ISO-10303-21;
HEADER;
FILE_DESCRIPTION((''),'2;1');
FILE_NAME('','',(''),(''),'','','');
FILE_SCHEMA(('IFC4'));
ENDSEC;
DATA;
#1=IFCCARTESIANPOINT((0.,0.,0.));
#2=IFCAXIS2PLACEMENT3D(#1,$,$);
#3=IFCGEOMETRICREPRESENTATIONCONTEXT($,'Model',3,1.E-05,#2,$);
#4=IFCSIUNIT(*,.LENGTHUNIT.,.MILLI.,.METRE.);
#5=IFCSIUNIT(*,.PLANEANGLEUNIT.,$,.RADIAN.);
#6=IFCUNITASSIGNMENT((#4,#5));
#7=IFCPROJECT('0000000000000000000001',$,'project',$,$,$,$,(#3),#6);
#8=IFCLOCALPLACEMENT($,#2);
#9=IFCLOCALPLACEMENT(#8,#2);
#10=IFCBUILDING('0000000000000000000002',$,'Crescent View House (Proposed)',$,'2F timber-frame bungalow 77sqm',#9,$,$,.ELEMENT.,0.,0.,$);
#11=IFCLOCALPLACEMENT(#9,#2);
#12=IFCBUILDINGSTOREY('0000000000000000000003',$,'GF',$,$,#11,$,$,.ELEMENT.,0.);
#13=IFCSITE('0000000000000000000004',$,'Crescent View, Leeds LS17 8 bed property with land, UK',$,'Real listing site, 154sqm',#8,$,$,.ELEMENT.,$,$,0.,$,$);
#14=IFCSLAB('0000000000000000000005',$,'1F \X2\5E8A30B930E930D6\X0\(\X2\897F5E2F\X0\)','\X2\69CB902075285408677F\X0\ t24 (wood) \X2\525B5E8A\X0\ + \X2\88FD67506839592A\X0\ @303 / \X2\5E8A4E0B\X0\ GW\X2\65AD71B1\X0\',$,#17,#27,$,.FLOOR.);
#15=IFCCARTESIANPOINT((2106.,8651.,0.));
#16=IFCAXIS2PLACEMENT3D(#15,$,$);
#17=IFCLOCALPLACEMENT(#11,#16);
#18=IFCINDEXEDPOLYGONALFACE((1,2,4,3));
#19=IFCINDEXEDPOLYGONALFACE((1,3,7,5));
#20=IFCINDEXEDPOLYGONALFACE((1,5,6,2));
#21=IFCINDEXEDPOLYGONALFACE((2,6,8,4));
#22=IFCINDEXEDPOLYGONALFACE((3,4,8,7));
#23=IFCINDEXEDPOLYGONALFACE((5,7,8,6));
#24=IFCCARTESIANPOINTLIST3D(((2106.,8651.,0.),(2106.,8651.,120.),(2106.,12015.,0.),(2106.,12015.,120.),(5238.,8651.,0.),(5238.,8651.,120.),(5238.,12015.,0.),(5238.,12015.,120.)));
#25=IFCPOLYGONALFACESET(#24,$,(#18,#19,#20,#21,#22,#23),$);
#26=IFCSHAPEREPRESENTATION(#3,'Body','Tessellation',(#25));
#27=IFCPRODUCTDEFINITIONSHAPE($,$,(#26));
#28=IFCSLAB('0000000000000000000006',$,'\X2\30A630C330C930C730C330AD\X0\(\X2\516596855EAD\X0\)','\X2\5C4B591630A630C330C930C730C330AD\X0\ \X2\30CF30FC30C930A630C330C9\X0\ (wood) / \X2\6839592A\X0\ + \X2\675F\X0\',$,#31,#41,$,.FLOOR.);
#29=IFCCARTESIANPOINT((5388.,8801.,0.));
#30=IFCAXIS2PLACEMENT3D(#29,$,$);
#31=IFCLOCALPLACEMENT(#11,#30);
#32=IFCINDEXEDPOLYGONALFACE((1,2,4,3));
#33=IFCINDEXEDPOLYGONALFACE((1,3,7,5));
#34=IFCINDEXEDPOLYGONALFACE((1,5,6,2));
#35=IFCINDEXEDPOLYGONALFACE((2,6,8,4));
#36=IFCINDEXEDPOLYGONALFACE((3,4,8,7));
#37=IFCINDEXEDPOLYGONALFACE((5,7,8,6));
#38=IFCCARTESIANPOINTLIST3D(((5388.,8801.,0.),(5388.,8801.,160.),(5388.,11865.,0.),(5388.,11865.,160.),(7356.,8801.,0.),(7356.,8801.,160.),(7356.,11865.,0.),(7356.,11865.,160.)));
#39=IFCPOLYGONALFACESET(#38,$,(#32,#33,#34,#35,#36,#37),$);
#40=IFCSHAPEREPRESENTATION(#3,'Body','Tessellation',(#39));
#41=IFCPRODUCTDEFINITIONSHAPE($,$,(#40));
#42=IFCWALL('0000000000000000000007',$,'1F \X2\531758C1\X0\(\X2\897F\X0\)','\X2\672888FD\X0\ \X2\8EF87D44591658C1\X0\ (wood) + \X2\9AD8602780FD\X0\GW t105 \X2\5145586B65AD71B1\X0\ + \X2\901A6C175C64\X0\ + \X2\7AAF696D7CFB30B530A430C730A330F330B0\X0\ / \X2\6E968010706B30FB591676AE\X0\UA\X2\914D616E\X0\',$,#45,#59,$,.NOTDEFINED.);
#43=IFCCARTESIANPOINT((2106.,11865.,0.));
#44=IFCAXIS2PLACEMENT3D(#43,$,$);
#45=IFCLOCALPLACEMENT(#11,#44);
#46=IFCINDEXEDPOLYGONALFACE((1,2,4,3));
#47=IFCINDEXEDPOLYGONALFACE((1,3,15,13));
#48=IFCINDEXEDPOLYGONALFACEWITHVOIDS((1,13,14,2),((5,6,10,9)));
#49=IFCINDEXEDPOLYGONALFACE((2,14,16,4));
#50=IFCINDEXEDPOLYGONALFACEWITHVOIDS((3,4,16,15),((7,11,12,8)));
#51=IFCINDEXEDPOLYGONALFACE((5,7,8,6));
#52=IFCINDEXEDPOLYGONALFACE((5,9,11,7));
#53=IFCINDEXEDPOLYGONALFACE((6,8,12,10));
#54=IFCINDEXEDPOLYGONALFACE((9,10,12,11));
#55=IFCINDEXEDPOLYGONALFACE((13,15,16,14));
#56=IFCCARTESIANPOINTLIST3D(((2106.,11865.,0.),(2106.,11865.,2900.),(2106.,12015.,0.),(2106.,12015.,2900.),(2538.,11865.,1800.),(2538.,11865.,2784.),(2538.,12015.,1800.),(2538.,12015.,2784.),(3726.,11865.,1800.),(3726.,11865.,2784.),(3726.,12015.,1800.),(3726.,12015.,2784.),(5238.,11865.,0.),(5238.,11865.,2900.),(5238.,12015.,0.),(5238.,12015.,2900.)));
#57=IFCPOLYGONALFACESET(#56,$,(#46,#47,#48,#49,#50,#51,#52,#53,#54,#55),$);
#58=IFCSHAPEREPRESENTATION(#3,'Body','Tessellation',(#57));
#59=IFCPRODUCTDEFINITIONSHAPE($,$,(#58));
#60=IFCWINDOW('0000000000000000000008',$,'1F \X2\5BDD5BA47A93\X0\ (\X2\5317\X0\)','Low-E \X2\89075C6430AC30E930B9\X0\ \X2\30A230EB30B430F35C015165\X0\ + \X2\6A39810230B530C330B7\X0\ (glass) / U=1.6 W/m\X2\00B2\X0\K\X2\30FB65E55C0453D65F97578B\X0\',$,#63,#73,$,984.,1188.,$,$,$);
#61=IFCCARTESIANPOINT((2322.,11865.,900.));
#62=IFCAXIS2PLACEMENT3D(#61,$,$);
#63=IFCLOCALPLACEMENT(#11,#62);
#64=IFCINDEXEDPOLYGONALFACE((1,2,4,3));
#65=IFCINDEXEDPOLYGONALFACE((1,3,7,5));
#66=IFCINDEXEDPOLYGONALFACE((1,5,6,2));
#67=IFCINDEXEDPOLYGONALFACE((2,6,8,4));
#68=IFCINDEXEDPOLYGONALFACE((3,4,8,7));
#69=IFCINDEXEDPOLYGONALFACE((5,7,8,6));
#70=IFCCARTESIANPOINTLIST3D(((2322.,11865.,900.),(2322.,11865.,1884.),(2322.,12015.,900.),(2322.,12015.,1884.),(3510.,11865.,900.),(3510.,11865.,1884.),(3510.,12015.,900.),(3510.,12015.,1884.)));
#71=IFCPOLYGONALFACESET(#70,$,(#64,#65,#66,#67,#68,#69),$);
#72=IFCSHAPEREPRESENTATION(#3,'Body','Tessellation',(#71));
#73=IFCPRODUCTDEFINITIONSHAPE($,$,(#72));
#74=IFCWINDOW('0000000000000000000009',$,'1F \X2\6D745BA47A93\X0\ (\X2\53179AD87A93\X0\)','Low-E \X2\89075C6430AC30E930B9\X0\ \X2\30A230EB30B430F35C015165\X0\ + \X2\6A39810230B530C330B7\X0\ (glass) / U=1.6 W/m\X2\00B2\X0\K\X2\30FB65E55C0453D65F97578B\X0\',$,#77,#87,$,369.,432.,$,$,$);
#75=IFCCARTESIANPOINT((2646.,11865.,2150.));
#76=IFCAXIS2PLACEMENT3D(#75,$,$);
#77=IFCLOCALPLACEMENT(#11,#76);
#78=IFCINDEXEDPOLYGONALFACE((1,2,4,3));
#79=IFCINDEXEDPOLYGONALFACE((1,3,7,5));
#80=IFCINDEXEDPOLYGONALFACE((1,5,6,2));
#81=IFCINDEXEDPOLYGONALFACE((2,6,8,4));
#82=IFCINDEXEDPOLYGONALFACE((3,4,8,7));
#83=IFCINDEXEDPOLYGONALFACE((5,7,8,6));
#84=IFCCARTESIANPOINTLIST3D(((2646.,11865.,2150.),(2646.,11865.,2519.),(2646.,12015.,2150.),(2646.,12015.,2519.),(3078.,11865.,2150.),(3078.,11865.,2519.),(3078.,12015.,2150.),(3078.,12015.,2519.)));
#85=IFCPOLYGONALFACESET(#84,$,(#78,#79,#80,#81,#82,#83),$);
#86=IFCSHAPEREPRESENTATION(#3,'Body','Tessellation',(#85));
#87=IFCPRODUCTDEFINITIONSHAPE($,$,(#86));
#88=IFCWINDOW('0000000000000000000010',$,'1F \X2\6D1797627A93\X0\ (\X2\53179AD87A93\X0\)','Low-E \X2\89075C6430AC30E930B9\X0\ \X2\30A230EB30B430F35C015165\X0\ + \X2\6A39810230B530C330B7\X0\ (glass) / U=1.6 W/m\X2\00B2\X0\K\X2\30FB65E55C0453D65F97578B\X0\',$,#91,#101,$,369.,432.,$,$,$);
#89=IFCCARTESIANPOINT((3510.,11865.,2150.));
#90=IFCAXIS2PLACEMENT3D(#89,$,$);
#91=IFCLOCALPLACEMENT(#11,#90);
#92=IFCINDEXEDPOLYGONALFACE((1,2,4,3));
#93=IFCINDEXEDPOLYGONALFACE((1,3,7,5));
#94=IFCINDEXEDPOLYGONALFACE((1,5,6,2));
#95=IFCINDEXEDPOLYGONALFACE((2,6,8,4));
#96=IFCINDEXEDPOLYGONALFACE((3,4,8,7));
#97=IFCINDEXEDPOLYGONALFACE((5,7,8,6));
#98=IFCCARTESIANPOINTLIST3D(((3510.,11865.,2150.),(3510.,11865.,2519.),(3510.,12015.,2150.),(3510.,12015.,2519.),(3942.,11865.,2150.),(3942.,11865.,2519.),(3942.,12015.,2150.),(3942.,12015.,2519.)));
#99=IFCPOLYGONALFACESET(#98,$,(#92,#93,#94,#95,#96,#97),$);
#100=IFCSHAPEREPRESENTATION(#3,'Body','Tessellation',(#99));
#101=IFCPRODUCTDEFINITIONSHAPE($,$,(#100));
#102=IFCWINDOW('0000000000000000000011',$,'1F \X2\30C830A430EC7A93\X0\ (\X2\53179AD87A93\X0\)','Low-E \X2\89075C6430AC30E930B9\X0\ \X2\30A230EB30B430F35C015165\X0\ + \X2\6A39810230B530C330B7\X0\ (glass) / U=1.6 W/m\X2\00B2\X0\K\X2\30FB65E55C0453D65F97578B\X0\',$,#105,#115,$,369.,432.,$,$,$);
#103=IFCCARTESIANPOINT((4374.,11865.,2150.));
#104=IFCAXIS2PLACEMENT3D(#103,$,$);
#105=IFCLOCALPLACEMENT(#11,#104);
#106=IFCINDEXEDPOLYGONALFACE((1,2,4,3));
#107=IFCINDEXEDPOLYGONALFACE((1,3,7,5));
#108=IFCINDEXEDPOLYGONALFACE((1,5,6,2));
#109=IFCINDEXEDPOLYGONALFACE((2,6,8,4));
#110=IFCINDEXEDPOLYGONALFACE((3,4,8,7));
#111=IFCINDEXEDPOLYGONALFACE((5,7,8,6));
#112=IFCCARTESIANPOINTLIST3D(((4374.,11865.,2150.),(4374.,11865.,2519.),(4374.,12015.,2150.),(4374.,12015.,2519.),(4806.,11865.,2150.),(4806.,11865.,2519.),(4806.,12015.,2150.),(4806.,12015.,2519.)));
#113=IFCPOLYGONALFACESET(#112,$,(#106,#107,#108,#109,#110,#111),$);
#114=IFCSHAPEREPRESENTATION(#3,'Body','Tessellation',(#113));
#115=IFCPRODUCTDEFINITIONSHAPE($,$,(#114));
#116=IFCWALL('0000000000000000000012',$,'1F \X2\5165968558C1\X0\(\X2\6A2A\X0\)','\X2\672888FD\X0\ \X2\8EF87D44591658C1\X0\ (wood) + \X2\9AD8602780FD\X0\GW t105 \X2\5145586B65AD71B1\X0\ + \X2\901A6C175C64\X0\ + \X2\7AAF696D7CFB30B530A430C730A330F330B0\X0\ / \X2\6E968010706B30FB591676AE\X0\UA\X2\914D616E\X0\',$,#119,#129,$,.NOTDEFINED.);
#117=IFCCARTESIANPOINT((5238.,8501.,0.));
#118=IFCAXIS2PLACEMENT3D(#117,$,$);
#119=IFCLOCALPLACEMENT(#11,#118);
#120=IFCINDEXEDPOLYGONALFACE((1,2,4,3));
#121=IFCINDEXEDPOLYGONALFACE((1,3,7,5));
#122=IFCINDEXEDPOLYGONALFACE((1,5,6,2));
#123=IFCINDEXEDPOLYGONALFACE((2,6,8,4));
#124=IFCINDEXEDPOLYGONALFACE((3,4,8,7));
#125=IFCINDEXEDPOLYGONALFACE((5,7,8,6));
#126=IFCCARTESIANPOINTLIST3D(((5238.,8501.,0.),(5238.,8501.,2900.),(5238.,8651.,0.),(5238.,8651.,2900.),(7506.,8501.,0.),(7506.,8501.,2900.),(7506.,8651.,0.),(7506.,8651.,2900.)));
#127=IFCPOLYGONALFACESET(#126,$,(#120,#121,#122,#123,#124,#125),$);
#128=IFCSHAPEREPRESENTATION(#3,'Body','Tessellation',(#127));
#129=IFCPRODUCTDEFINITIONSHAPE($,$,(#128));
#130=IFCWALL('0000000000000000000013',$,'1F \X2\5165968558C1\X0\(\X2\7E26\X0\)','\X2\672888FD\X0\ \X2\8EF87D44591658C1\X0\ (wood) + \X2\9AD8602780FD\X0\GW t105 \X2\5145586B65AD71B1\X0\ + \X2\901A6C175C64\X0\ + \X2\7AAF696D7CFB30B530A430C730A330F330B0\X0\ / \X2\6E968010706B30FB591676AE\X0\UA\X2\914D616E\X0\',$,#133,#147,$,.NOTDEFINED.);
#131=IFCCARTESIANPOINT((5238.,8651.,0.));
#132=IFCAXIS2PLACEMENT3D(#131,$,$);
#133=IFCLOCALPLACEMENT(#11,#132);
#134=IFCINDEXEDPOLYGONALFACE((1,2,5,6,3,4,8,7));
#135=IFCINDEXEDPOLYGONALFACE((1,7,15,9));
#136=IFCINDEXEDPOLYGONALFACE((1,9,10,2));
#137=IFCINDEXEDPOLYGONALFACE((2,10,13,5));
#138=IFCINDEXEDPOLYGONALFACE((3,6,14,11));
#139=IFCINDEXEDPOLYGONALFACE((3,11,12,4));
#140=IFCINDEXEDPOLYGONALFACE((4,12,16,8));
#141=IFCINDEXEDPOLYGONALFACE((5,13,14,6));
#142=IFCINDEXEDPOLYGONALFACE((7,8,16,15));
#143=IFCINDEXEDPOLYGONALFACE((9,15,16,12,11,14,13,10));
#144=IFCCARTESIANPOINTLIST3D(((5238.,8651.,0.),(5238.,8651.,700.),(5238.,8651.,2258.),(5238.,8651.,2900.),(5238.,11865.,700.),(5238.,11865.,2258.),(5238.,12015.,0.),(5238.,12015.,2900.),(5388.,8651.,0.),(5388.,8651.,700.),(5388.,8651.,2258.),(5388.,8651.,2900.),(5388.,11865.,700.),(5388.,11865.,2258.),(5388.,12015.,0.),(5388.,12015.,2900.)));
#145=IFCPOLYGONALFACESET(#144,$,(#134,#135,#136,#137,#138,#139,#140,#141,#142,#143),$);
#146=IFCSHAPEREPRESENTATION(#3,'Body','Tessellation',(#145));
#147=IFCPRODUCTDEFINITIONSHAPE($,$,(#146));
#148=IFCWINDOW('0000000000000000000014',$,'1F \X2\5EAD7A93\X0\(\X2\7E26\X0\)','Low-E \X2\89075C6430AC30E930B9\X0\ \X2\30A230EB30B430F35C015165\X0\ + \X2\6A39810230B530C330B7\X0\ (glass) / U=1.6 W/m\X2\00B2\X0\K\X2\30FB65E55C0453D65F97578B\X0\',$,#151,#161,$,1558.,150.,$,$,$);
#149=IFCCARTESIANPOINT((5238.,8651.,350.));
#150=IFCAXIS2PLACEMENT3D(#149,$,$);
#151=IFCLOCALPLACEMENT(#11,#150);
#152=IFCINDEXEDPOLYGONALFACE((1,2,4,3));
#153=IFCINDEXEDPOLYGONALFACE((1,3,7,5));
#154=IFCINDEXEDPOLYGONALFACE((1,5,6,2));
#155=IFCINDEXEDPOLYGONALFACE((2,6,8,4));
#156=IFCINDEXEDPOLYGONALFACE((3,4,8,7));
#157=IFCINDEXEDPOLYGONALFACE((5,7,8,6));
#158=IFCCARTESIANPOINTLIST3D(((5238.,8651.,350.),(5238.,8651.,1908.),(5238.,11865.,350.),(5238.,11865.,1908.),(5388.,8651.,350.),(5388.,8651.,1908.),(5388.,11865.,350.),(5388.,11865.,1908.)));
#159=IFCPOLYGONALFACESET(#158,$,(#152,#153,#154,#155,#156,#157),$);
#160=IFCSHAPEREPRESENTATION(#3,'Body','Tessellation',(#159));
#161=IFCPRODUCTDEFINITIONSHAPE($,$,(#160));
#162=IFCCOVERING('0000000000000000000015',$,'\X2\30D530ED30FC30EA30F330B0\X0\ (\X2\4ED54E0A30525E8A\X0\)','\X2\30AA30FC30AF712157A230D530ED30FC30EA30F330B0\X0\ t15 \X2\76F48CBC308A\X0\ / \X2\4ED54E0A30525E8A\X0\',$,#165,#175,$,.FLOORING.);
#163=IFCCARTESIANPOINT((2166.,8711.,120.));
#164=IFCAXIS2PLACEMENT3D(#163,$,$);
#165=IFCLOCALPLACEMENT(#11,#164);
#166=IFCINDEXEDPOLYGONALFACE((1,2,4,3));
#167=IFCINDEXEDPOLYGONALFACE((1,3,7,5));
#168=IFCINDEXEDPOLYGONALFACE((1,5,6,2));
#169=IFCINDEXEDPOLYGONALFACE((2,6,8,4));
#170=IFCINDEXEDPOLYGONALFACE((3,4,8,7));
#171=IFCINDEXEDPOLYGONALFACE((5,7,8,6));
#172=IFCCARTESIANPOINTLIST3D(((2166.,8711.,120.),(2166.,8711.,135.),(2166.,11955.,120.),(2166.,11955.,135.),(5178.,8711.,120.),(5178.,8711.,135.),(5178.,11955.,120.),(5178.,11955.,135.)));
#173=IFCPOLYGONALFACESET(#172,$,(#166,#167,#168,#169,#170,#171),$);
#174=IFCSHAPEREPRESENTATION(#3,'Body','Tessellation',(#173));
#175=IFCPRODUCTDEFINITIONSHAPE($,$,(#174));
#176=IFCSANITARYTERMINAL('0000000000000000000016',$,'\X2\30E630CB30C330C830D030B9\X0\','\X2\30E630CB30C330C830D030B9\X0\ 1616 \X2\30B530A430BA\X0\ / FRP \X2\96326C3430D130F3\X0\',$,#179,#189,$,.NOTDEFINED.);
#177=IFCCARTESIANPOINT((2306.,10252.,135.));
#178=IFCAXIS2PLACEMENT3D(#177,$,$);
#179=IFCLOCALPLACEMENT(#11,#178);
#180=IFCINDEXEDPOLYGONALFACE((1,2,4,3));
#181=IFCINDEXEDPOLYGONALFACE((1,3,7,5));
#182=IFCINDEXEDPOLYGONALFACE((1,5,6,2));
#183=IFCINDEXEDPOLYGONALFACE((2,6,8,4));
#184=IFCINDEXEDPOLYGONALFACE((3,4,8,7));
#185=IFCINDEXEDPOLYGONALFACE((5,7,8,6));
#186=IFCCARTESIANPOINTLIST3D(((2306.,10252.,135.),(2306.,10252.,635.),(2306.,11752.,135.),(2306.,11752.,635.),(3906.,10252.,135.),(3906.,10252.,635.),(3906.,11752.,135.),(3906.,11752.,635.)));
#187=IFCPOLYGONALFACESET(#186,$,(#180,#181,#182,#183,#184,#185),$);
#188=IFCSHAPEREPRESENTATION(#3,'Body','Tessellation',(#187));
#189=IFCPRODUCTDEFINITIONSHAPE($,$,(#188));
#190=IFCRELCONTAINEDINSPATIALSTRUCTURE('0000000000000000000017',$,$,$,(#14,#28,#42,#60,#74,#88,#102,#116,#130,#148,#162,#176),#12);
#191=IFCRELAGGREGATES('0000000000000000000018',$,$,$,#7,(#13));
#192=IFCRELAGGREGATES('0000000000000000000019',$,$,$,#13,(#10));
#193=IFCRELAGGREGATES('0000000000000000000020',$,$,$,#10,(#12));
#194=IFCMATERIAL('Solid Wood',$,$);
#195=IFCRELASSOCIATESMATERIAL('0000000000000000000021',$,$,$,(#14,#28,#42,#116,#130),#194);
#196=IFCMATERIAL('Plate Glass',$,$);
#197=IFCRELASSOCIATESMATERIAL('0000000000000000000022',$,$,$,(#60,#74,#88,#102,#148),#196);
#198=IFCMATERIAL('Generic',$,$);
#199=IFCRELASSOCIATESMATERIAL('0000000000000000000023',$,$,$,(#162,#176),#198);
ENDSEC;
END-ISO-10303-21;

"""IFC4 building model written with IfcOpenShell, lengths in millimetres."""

from ifc_helpers import new_model, si_unit, frame, frame_2d, origin, place, context, project, spatial, rectangle, extrude, material, element, fill, save


model = new_model("IFC4")

# Units and contexts
model_context = context("Model", 3, precision=1e-05, world=origin())
ifc_project = project(units=[si_unit("LENGTHUNIT", "METRE", prefix="MILLI"), si_unit("PLANEANGLEUNIT", "RADIAN")], contexts=[model_context])

# Site, building, storey
site_placement = place(None, origin())
site = spatial("IfcSite", under=ifc_project, at=site_placement, Name="Crescent View, Leeds LS17 8 bed property with land, UK", ObjectType="Real listing site, 154sqm", CompositionType="ELEMENT", RefElevation=0.0)
building_placement = place(site_placement, origin())
building = spatial("IfcBuilding", under=site, at=building_placement, Name="Crescent View House (Proposed)", ObjectType="2F timber-frame bungalow 77sqm", CompositionType="ELEMENT", ElevationOfRefHeight=0.0, ElevationOfTerrain=0.0)
storey_placement = place(building_placement, origin())
storey = spatial("IfcBuildingStorey", under=building, at=storey_placement, Name="GF", CompositionType="ELEMENT", Elevation=0.0)

# Slabs
ifc_material_1 = material(Name="Solid Wood")
slab_1_placement = place(storey_placement, frame((2106.0, 8651.0, 0.0)))
element("IfcSlab", 1, at=slab_1_placement, inside=storey, material=ifc_material_1, Name="1F 床スラブ(西帯)", Description="構造用合板 t24 (wood) 剛床 + 製材根太 @303 / 床下 GW断熱", PredefinedType="FLOOR", context=model_context, shape_type="SweptSolid", body=[
    extrude(rectangle(XDim=3132.0, YDim=3364.0, at=frame_2d((1566.0, 1682.0))), frame((2106.0, 8651.0, 0.0)), (0.0, 0.0, 1.0), 120.0),
])
slab_2_placement = place(storey_placement, frame((5388.0, 8801.0, 0.0)))
element("IfcSlab", 2, at=slab_2_placement, inside=storey, material=ifc_material_1, Name="ウッドデッキ(入隅庭)", Description="屋外ウッドデッキ ハードウッド (wood) / 根太 + 束", PredefinedType="FLOOR", context=model_context, shape_type="SweptSolid", body=[
    extrude(rectangle(XDim=1968.0, YDim=3064.0, at=frame_2d((984.0, 1532.0))), frame((5388.0, 8801.0, 0.0)), (0.0, 0.0, 1.0), 160.0),
])

# Wall, openings, windows
wall_1_placement = place(storey_placement, frame((2106.0, 11865.0, 0.0)))
wall_1 = element("IfcWall", 3, at=wall_1_placement, inside=storey, material=ifc_material_1, Name="1F 北壁(西)", Description="木製 軸組外壁 (wood) + 高性能GW t105 充填断熱 + 通気層 + 窯業系サイディング / 準耐火・外皮UA配慮", PredefinedType="NOTDEFINED", context=model_context, shape_type="SweptSolid", body=[
    extrude(rectangle(XDim=3132.0, YDim=150.0, at=frame_2d((1566.0, 75.0))), frame((2106.0, 11865.0, 0.0)), (0.0, 0.0, 1.0), 2900.0),
])
opening_1_placement = place(storey_placement, frame((2322.0, 11865.0, 900.0)))
opening_1 = element("IfcOpeningElement", 4, at=opening_1_placement, cuts=wall_1, PredefinedType="NOTDEFINED", context=model_context, shape_type="SweptSolid", body=[
    extrude(rectangle(XDim=1188.0, YDim=150.0, at=frame_2d((594.0, 75.0))), frame((2322.0, 11865.0, 900.0)), (0.0, 0.0, 1.0), 984.0),
])
opening_2_placement = place(storey_placement, frame((2646.0, 11865.0, 2150.0)))
opening_2 = element("IfcOpeningElement", 5, at=opening_2_placement, cuts=wall_1, PredefinedType="NOTDEFINED", context=model_context, shape_type="SweptSolid", body=[
    extrude(rectangle(XDim=432.0, YDim=150.0, at=frame_2d((216.0, 75.0))), frame((2646.0, 11865.0, 2150.0)), (0.0, 0.0, 1.0), 369.0),
])
opening_3_placement = place(storey_placement, frame((3510.0, 11865.0, 2150.0)))
opening_3 = element("IfcOpeningElement", 6, at=opening_3_placement, cuts=wall_1, PredefinedType="NOTDEFINED", context=model_context, shape_type="SweptSolid", body=[
    extrude(rectangle(XDim=432.0, YDim=150.0, at=frame_2d((216.0, 75.0))), frame((3510.0, 11865.0, 2150.0)), (0.0, 0.0, 1.0), 369.0),
])
opening_4_placement = place(storey_placement, frame((4374.0, 11865.0, 2150.0)))
opening_4 = element("IfcOpeningElement", 7, at=opening_4_placement, cuts=wall_1, PredefinedType="NOTDEFINED", context=model_context, shape_type="SweptSolid", body=[
    extrude(rectangle(XDim=432.0, YDim=150.0, at=frame_2d((216.0, 75.0))), frame((4374.0, 11865.0, 2150.0)), (0.0, 0.0, 1.0), 369.0),
])
ifc_material_2 = material(Name="Plate Glass")
window_1_placement = place(storey_placement, frame((2322.0, 11865.0, 900.0)))
window_1 = element("IfcWindow", 8, at=window_1_placement, inside=storey, material=ifc_material_2, Name="1F 寝室窓 (北)", Description="Low-E 複層ガラス アルゴン封入 + 樹脂サッシ (glass) / U=1.6 W/m²K・日射取得型", OverallHeight=984.0, OverallWidth=1188.0, context=model_context, shape_type="SweptSolid", body=[
    extrude(rectangle(XDim=1188.0, YDim=150.0, at=frame_2d((594.0, 75.0))), frame((2322.0, 11865.0, 900.0)), (0.0, 0.0, 1.0), 984.0),
])
fill(opening_1, window_1)
window_2_placement = place(storey_placement, frame((2646.0, 11865.0, 2150.0)))
window_2 = element("IfcWindow", 9, at=window_2_placement, inside=storey, material=ifc_material_2, Name="1F 浴室窓 (北高窓)", Description="Low-E 複層ガラス アルゴン封入 + 樹脂サッシ (glass) / U=1.6 W/m²K・日射取得型", OverallHeight=369.0, OverallWidth=432.0, context=model_context, shape_type="SweptSolid", body=[
    extrude(rectangle(XDim=432.0, YDim=150.0, at=frame_2d((216.0, 75.0))), frame((2646.0, 11865.0, 2150.0)), (0.0, 0.0, 1.0), 369.0),
])
fill(opening_2, window_2)
window_3_placement = place(storey_placement, frame((3510.0, 11865.0, 2150.0)))
window_3 = element("IfcWindow", 10, at=window_3_placement, inside=storey, material=ifc_material_2, Name="1F 洗面窓 (北高窓)", Description="Low-E 複層ガラス アルゴン封入 + 樹脂サッシ (glass) / U=1.6 W/m²K・日射取得型", OverallHeight=369.0, OverallWidth=432.0, context=model_context, shape_type="SweptSolid", body=[
    extrude(rectangle(XDim=432.0, YDim=150.0, at=frame_2d((216.0, 75.0))), frame((3510.0, 11865.0, 2150.0)), (0.0, 0.0, 1.0), 369.0),
])
fill(opening_3, window_3)
window_4_placement = place(storey_placement, frame((4374.0, 11865.0, 2150.0)))
window_4 = element("IfcWindow", 11, at=window_4_placement, inside=storey, material=ifc_material_2, Name="1F トイレ窓 (北高窓)", Description="Low-E 複層ガラス アルゴン封入 + 樹脂サッシ (glass) / U=1.6 W/m²K・日射取得型", OverallHeight=369.0, OverallWidth=432.0, context=model_context, shape_type="SweptSolid", body=[
    extrude(rectangle(XDim=432.0, YDim=150.0, at=frame_2d((216.0, 75.0))), frame((4374.0, 11865.0, 2150.0)), (0.0, 0.0, 1.0), 369.0),
])
fill(opening_4, window_4)

# Wall
wall_2_placement = place(storey_placement, frame((5238.0, 8501.0, 0.0)))
element("IfcWall", 12, at=wall_2_placement, inside=storey, material=ifc_material_1, Name="1F 入隅壁(横)", Description="木製 軸組外壁 (wood) + 高性能GW t105 充填断熱 + 通気層 + 窯業系サイディング / 準耐火・外皮UA配慮", PredefinedType="NOTDEFINED", context=model_context, shape_type="SweptSolid", body=[
    extrude(rectangle(XDim=2268.0, YDim=150.0, at=frame_2d((1134.0, 75.0))), frame((5238.0, 8501.0, 0.0)), (0.0, 0.0, 1.0), 2900.0),
])

# Wall, opening, window
wall_3_placement = place(storey_placement, frame((5238.0, 8651.0, 0.0)))
wall_3 = element("IfcWall", 13, at=wall_3_placement, inside=storey, material=ifc_material_1, Name="1F 入隅壁(縦)", Description="木製 軸組外壁 (wood) + 高性能GW t105 充填断熱 + 通気層 + 窯業系サイディング / 準耐火・外皮UA配慮", PredefinedType="NOTDEFINED", context=model_context, shape_type="SweptSolid", body=[
    extrude(rectangle(XDim=150.0, YDim=3364.0, at=frame_2d((75.0, 1682.0))), frame((5238.0, 8651.0, 0.0)), (0.0, 0.0, 1.0), 2900.0),
])
opening_5_placement = place(storey_placement, frame((5238.0, 8651.0, 350.0)))
opening_5 = element("IfcOpeningElement", 14, at=opening_5_placement, cuts=wall_3, PredefinedType="NOTDEFINED", context=model_context, shape_type="SweptSolid", body=[
    extrude(rectangle(XDim=150.0, YDim=3214.0, at=frame_2d((75.0, 1607.0))), frame((5238.0, 8651.0, 350.0)), (0.0, 0.0, 1.0), 1558.0),
])
window_5_placement = place(storey_placement, frame((5238.0, 8651.0, 350.0)))
window_5 = element("IfcWindow", 15, at=window_5_placement, inside=storey, material=ifc_material_2, Name="1F 庭窓(縦)", Description="Low-E 複層ガラス アルゴン封入 + 樹脂サッシ (glass) / U=1.6 W/m²K・日射取得型", OverallHeight=1558.0, OverallWidth=150.0, context=model_context, shape_type="SweptSolid", body=[
    extrude(rectangle(XDim=150.0, YDim=3214.0, at=frame_2d((75.0, 1607.0))), frame((5238.0, 8651.0, 350.0)), (0.0, 0.0, 1.0), 1558.0),
])
fill(opening_5, window_5)

# Covering
ifc_material_3 = material(Name="Generic")
covering_placement = place(storey_placement, frame((2166.0, 8711.0, 120.0)))
element("IfcCovering", 16, at=covering_placement, inside=storey, material=ifc_material_3, Name="フローリング (仕上げ床)", Description="オーク無垢フローリング t15 直貼り / 仕上げ床", PredefinedType="FLOORING", context=model_context, shape_type="SweptSolid", body=[
    extrude(rectangle(XDim=3012.0, YDim=3244.0, at=frame_2d((1506.0, 1622.0))), frame((2166.0, 8711.0, 120.0)), (0.0, 0.0, 1.0), 15.0),
])

# Sanitary terminal
sanitary_terminal_1_placement = place(storey_placement, frame((2306.0, 10252.0, 135.0)))
element("IfcSanitaryTerminal", 17, at=sanitary_terminal_1_placement, inside=storey, material=ifc_material_3, Name="ユニットバス", Description="ユニットバス 1616 サイズ / FRP 防水パン", PredefinedType="NOTDEFINED", context=model_context, shape_type="SweptSolid", body=[
    extrude(rectangle(XDim=1600.0, YDim=1500.0, at=frame_2d((800.0, 750.0))), frame((2306.0, 10252.0, 135.0)), (0.0, 0.0, 1.0), 500.0),
])

save(model, "model.ifc")
